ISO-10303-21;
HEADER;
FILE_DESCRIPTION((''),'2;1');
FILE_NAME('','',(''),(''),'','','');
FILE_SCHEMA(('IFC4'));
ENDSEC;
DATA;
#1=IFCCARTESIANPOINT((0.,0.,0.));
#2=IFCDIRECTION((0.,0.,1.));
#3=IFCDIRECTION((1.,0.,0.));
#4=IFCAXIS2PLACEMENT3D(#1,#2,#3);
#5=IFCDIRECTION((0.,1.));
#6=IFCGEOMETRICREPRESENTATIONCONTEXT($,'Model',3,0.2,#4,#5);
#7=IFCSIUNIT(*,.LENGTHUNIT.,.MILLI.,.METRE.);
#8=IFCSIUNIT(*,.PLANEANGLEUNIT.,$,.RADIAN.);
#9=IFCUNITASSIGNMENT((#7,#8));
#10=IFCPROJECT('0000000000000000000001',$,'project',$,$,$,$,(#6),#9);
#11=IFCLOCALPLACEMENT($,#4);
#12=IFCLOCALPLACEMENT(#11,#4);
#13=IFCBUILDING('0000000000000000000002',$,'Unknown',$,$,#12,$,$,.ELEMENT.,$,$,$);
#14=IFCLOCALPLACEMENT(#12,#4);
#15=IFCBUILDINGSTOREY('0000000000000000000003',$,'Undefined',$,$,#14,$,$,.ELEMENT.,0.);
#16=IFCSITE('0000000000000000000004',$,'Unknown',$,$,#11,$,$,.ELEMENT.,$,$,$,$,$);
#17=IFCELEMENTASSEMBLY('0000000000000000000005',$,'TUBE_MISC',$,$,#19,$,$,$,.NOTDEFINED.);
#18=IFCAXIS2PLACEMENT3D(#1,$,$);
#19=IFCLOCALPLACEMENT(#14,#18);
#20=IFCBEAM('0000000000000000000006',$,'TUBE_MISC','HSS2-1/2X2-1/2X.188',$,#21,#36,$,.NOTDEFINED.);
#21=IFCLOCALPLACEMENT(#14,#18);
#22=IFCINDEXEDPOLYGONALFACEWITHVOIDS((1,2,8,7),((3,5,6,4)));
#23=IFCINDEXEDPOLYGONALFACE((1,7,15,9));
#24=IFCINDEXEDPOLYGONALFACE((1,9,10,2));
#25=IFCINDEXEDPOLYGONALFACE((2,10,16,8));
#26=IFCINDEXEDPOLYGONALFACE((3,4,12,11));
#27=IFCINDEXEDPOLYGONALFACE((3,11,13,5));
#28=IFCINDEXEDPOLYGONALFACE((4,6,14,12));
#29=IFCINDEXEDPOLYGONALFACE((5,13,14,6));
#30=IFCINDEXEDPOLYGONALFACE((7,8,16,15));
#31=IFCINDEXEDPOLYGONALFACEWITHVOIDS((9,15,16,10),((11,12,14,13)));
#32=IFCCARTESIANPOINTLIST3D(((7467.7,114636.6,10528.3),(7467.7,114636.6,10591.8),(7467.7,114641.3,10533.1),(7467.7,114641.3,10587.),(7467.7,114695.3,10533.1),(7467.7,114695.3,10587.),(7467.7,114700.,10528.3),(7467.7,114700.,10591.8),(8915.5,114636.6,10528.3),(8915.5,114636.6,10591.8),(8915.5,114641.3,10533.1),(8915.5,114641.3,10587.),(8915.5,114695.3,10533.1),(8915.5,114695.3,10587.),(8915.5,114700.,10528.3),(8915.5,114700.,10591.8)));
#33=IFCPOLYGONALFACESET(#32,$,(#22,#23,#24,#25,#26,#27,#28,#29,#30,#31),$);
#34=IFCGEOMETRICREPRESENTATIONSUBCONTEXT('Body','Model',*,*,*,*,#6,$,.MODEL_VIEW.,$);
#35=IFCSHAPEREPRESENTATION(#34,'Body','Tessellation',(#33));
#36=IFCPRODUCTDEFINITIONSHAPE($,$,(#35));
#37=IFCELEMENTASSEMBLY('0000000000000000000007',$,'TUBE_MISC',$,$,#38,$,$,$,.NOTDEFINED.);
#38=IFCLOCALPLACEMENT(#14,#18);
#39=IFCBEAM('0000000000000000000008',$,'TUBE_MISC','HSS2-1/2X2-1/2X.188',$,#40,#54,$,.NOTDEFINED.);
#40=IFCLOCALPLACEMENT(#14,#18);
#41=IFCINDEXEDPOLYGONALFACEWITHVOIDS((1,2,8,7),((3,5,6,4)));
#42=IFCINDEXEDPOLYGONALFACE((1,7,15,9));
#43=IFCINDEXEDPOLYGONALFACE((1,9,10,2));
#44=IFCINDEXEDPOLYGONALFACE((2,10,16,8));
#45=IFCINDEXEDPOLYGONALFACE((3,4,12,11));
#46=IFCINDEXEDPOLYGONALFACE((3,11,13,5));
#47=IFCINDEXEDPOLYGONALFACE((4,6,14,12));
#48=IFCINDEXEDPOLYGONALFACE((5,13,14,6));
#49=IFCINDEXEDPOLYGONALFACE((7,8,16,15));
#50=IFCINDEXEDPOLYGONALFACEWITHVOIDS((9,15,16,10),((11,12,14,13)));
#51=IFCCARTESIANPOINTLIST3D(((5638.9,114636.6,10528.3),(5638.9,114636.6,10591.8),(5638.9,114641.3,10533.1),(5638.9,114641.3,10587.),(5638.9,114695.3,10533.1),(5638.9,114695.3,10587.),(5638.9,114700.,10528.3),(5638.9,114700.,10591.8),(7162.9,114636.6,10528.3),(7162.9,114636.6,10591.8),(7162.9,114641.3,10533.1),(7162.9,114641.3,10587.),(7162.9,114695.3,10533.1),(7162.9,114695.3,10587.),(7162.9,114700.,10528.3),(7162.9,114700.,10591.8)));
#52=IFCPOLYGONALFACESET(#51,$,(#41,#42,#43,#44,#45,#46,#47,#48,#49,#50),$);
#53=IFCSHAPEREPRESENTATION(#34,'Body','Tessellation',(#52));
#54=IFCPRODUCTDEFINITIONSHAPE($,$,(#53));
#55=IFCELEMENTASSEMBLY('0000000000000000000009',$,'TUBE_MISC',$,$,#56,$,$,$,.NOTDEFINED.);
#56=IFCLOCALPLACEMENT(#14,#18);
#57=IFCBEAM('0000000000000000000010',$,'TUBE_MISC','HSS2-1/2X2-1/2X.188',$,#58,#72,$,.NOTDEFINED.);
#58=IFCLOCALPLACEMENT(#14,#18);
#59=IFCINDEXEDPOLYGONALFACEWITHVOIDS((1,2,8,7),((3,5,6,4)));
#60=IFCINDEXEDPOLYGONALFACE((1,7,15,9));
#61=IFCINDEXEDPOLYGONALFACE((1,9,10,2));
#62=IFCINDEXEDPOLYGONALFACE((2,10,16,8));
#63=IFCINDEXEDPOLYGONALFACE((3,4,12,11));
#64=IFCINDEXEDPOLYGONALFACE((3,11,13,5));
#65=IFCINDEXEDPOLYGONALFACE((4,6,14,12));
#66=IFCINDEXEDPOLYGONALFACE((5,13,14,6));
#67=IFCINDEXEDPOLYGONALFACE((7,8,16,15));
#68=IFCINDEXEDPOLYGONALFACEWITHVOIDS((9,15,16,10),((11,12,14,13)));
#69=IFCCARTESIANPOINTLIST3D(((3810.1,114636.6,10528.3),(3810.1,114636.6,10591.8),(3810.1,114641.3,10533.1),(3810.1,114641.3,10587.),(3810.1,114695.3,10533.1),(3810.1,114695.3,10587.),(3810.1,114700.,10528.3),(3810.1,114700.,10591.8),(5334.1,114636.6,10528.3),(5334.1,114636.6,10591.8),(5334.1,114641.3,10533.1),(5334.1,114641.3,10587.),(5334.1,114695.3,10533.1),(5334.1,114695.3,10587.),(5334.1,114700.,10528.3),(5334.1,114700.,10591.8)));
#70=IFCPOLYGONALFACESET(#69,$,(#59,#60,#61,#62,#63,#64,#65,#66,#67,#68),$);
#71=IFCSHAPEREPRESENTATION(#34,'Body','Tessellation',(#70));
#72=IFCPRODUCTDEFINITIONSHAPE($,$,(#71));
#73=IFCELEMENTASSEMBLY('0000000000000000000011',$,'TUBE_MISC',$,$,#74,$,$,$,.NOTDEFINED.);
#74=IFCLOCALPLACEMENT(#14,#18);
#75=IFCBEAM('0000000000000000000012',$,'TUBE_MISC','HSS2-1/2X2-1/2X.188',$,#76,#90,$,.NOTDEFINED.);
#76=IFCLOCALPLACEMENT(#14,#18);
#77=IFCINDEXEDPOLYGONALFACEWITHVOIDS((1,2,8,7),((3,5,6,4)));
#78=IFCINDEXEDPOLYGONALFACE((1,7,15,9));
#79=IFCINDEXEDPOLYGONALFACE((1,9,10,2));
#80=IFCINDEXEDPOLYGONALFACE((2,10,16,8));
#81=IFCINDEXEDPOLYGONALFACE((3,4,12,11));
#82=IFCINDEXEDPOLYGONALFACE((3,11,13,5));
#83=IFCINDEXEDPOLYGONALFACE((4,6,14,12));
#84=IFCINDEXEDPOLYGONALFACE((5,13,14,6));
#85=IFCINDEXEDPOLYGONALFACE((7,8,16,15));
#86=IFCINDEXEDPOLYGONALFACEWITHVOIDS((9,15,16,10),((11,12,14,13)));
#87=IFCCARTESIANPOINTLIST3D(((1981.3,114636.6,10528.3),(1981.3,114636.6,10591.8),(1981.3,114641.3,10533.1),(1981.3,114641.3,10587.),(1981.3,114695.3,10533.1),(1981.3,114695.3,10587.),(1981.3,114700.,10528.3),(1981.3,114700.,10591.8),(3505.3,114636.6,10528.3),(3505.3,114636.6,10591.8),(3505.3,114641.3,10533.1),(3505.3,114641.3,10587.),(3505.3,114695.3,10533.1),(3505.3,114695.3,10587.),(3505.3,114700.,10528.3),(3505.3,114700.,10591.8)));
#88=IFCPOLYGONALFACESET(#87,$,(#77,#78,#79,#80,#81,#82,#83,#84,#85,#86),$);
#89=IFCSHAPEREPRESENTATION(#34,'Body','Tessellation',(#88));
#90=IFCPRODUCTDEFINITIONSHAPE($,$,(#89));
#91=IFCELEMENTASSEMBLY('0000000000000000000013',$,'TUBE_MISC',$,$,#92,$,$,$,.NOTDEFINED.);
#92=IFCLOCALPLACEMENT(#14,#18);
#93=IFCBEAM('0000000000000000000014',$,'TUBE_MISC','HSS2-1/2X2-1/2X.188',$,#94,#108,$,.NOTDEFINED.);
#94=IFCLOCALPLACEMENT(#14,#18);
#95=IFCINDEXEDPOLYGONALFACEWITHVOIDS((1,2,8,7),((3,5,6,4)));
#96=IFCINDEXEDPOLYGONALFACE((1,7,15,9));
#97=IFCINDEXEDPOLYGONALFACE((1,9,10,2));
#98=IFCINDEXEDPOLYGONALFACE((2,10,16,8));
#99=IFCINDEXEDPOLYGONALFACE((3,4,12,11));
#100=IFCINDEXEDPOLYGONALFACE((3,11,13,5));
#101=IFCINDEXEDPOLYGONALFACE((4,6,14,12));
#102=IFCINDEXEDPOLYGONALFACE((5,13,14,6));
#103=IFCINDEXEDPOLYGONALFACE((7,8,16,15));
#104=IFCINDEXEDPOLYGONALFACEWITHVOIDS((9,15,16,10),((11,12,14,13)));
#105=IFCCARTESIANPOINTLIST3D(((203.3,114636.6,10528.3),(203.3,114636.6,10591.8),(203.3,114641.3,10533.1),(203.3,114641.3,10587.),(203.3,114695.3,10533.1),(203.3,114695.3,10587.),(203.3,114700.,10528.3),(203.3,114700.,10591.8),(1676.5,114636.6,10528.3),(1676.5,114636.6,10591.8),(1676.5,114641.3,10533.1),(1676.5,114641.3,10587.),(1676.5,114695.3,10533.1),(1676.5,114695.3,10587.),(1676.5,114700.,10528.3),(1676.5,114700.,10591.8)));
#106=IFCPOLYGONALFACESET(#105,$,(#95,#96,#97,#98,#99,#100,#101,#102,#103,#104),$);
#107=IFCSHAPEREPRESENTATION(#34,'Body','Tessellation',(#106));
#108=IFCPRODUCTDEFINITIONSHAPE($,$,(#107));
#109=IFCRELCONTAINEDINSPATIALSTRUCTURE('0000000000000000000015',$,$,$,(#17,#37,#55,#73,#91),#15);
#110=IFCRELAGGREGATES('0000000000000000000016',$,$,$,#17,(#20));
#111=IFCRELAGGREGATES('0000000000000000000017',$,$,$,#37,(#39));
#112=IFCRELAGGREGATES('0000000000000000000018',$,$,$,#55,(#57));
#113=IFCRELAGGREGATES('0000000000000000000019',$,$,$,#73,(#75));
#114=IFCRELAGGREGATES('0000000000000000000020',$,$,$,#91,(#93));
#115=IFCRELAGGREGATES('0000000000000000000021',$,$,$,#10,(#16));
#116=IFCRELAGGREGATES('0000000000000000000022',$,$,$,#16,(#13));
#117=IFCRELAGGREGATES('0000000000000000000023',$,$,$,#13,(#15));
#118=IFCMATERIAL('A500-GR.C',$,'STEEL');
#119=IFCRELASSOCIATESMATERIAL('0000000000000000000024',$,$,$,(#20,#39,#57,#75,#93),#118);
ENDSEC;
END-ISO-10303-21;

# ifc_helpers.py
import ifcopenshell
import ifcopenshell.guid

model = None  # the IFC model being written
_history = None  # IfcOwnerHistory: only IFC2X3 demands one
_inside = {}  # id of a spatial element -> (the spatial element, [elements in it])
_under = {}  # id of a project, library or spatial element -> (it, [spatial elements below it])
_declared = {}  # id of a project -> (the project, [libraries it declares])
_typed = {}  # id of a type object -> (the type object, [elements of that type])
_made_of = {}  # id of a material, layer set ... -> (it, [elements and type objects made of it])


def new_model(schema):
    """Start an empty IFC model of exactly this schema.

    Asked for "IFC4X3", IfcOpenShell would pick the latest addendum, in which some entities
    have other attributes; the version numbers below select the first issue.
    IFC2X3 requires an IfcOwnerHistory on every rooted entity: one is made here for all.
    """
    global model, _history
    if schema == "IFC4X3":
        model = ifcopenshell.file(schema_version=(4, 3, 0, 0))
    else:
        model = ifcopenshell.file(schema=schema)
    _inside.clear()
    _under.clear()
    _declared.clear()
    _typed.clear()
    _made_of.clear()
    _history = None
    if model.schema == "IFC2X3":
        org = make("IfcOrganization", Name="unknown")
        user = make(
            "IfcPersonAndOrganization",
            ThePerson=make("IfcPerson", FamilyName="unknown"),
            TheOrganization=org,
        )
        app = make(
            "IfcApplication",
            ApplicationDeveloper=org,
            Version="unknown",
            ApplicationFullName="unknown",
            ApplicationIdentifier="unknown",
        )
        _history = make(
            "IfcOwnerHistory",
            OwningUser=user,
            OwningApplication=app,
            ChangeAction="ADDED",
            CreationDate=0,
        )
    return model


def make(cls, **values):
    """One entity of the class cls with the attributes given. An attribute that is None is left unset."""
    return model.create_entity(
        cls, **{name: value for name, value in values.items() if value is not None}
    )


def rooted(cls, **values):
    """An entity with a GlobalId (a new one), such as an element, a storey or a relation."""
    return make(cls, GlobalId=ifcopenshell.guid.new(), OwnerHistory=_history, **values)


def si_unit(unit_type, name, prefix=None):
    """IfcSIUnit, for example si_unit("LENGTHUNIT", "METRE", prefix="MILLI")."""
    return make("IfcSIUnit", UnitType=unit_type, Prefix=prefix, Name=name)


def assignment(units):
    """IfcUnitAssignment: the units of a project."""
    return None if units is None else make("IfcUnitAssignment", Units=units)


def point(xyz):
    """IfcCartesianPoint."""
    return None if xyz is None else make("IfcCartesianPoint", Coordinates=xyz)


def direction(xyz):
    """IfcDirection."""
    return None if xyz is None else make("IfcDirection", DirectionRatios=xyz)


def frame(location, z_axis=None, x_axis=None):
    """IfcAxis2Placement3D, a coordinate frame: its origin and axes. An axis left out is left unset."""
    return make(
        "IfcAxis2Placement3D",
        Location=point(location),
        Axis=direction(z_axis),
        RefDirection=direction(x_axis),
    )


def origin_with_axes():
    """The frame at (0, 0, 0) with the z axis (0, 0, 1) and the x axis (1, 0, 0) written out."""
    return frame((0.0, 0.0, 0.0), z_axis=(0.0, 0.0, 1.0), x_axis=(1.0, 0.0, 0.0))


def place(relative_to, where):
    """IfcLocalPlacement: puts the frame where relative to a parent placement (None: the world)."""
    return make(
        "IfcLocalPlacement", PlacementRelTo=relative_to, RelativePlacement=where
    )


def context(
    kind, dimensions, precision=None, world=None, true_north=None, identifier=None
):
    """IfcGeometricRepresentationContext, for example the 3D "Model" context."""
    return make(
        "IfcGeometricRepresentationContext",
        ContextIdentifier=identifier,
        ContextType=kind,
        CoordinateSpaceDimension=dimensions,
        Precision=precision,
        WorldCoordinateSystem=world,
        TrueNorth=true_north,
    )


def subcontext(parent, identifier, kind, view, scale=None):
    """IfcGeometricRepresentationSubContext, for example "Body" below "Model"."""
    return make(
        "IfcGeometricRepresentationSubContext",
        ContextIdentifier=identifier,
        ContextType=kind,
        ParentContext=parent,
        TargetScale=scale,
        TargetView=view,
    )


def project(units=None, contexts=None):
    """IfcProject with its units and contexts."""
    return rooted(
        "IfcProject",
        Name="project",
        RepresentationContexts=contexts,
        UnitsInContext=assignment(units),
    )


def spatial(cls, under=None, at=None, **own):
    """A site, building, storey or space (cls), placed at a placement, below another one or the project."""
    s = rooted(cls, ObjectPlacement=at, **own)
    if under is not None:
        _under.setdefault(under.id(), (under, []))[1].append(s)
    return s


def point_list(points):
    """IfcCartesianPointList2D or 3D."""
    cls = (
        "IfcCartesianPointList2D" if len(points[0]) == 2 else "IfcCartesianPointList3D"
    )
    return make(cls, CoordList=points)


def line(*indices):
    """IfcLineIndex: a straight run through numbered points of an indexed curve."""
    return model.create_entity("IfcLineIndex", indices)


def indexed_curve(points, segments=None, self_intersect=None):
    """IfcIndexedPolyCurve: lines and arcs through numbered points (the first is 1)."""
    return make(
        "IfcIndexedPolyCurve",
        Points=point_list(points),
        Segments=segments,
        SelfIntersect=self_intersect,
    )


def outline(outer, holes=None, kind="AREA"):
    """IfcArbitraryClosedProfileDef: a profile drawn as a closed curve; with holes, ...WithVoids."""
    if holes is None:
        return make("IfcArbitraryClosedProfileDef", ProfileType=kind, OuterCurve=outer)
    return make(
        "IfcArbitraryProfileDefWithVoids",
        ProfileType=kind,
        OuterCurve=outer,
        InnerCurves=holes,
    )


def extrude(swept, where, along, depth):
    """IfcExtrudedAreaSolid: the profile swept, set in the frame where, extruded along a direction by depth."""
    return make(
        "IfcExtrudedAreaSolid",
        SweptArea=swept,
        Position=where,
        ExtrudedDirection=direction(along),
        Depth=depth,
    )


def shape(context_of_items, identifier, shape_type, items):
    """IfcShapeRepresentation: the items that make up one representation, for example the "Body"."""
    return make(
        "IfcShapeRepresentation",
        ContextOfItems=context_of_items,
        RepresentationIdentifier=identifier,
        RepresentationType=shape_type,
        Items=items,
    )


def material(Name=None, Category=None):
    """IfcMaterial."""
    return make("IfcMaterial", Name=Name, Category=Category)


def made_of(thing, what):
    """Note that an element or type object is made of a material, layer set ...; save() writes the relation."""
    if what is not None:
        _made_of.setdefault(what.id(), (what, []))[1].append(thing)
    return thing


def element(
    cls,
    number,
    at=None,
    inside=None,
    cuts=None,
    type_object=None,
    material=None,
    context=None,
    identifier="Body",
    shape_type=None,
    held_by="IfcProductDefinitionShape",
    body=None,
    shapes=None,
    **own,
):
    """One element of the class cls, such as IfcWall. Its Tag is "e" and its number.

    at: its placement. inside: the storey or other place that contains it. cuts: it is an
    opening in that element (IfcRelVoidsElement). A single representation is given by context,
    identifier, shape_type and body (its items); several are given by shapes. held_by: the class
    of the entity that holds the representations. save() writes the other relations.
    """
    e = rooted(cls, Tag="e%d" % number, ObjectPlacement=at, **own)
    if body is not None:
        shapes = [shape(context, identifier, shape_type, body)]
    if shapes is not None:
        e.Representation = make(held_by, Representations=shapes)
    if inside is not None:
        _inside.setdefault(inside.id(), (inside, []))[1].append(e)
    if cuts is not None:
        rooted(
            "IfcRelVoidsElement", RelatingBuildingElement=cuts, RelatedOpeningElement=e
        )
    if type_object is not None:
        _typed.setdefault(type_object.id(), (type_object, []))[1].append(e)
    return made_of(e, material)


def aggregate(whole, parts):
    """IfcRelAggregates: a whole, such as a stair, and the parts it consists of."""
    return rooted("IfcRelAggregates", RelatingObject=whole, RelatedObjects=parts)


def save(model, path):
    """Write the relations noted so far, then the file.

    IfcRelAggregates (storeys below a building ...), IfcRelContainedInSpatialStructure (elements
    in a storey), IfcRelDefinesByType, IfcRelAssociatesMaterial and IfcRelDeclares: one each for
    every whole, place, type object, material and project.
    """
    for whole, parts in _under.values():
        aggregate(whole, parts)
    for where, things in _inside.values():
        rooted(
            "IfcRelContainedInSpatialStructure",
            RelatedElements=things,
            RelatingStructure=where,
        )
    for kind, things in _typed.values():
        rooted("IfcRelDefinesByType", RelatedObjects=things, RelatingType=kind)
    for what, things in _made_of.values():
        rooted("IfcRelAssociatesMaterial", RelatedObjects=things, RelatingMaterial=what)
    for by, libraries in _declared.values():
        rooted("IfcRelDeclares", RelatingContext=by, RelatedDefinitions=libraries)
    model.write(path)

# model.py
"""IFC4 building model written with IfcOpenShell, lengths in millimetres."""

from ifc_helpers import new_model, si_unit, direction, frame, origin_with_axes, place, context, subcontext, project, spatial, line, indexed_curve, outline, extrude, material, element, aggregate, save


model = new_model("IFC4")

# Units and contexts
model_context = context("Model", 3, precision=0.2, world=origin_with_axes(), true_north=direction((0.0, 1.0)))
body_context = subcontext(model_context, "Body", "Model", "MODEL_VIEW")
ifc_project = project(units=[si_unit("LENGTHUNIT", "METRE", prefix="MILLI"), si_unit("PLANEANGLEUNIT", "RADIAN")], contexts=[model_context])

# Site, building, storey
site_placement = place(None, origin_with_axes())
site = spatial("IfcSite", under=ifc_project, at=site_placement, Name="Unknown", CompositionType="ELEMENT")
building_placement = place(site_placement, origin_with_axes())
building = spatial("IfcBuilding", under=site, at=building_placement, Name="Unknown", CompositionType="ELEMENT")
storey_placement = place(building_placement, origin_with_axes())
storey = spatial("IfcBuildingStorey", under=building, at=storey_placement, Name="Undefined", CompositionType="ELEMENT", Elevation=0.0)

# Element assemblies, beams
assembly_1_placement = place(storey_placement, frame((7467.7, 114668.3, 10560.0), z_axis=(0.0, -1.0, 0.0), x_axis=(1.0, 0.0, 0.0)))
assembly_1 = element("IfcElementAssembly", 1, at=assembly_1_placement, inside=storey, Name="TUBE_MISC", PredefinedType="NOTDEFINED")
ifc_material_1 = material(Name="A500-GR.C", Category="STEEL")
beam_1_placement = place(assembly_1_placement, origin_with_axes())
beam_1 = element("IfcBeam", 2, at=beam_1_placement, material=ifc_material_1, Name="TUBE_MISC", Description="HSS2-1/2X2-1/2X.188", PredefinedType="NOTDEFINED", context=body_context, shape_type="SolidModel", body=[
    extrude(outline(indexed_curve([(-31.8, -31.8), (31.8, -31.8), (31.8, 31.8), (-31.8, 31.8)], segments=[line(1, 2, 3, 4, 1)]), holes=[indexed_curve([(-27.0, -27.0), (-27.0, 27.0), (27.0, 27.0), (27.0, -27.0)], segments=[line(1, 2, 3, 4, 1)])]), frame((0.0, 0.0, 0.0), z_axis=(-1.0, 0.0, 0.0), x_axis=(0.0, 0.0, 1.0)), (0.0, 0.0, -1.0), 1447.8),
])
aggregate(assembly_1, [beam_1])
assembly_2_placement = place(storey_placement, frame((5638.9, 114668.3, 10560.0), z_axis=(0.0, -1.0, 0.0), x_axis=(1.0, 0.0, 0.0)))
assembly_2 = element("IfcElementAssembly", 3, at=assembly_2_placement, inside=storey, Name="TUBE_MISC", PredefinedType="NOTDEFINED")
beam_2_placement = place(assembly_2_placement, origin_with_axes())
beam_2 = element("IfcBeam", 4, at=beam_2_placement, material=ifc_material_1, Name="TUBE_MISC", Description="HSS2-1/2X2-1/2X.188", PredefinedType="NOTDEFINED", context=body_context, shape_type="SolidModel", body=[
    extrude(outline(indexed_curve([(-31.8, -31.8), (31.8, -31.8), (31.8, 31.8), (-31.8, 31.8)], segments=[line(1, 2, 3, 4, 1)]), holes=[indexed_curve([(-27.0, -27.0), (-27.0, 27.0), (27.0, 27.0), (27.0, -27.0)], segments=[line(1, 2, 3, 4, 1)])]), frame((0.0, 0.0, 0.0), z_axis=(-1.0, 0.0, 0.0), x_axis=(0.0, 0.0, 1.0)), (0.0, 0.0, -1.0), 1524.0),
])
aggregate(assembly_2, [beam_2])
assembly_3_placement = place(storey_placement, frame((3810.1, 114668.3, 10560.0), z_axis=(0.0, -1.0, 0.0), x_axis=(1.0, 0.0, 0.0)))
assembly_3 = element("IfcElementAssembly", 5, at=assembly_3_placement, inside=storey, Name="TUBE_MISC", PredefinedType="NOTDEFINED")
beam_3_placement = place(assembly_3_placement, origin_with_axes())
beam_3 = element("IfcBeam", 6, at=beam_3_placement, material=ifc_material_1, Name="TUBE_MISC", Description="HSS2-1/2X2-1/2X.188", PredefinedType="NOTDEFINED", context=body_context, shape_type="SolidModel", body=[
    extrude(outline(indexed_curve([(-31.8, -31.8), (31.8, -31.8), (31.8, 31.8), (-31.8, 31.8)], segments=[line(1, 2, 3, 4, 1)]), holes=[indexed_curve([(-27.0, -27.0), (-27.0, 27.0), (27.0, 27.0), (27.0, -27.0)], segments=[line(1, 2, 3, 4, 1)])]), frame((0.0, 0.0, 0.0), z_axis=(-1.0, 0.0, 0.0), x_axis=(0.0, 0.0, 1.0)), (0.0, 0.0, -1.0), 1524.0),
])
aggregate(assembly_3, [beam_3])
assembly_4_placement = place(storey_placement, frame((1981.3, 114668.3, 10560.0), z_axis=(0.0, -1.0, 0.0), x_axis=(1.0, 0.0, 0.0)))
assembly_4 = element("IfcElementAssembly", 7, at=assembly_4_placement, inside=storey, Name="TUBE_MISC", PredefinedType="NOTDEFINED")
beam_4_placement = place(assembly_4_placement, origin_with_axes())
beam_4 = element("IfcBeam", 8, at=beam_4_placement, material=ifc_material_1, Name="TUBE_MISC", Description="HSS2-1/2X2-1/2X.188", PredefinedType="NOTDEFINED", context=body_context, shape_type="SolidModel", body=[
    extrude(outline(indexed_curve([(-31.8, -31.8), (31.8, -31.8), (31.8, 31.8), (-31.8, 31.8)], segments=[line(1, 2, 3, 4, 1)]), holes=[indexed_curve([(-27.0, -27.0), (-27.0, 27.0), (27.0, 27.0), (27.0, -27.0)], segments=[line(1, 2, 3, 4, 1)])]), frame((0.0, 0.0, 0.0), z_axis=(-1.0, 0.0, 0.0), x_axis=(0.0, 0.0, 1.0)), (0.0, 0.0, -1.0), 1524.0),
])
aggregate(assembly_4, [beam_4])
assembly_5_placement = place(storey_placement, frame((203.3, 114668.3, 10560.0), z_axis=(0.0, -1.0, 0.0), x_axis=(1.0, 0.0, 0.0)))
assembly_5 = element("IfcElementAssembly", 9, at=assembly_5_placement, inside=storey, Name="TUBE_MISC", PredefinedType="NOTDEFINED")
beam_5_placement = place(assembly_5_placement, origin_with_axes())
beam_5 = element("IfcBeam", 10, at=beam_5_placement, material=ifc_material_1, Name="TUBE_MISC", Description="HSS2-1/2X2-1/2X.188", PredefinedType="NOTDEFINED", context=body_context, shape_type="SolidModel", body=[
    extrude(outline(indexed_curve([(-31.8, -31.8), (31.8, -31.8), (31.8, 31.8), (-31.8, 31.8)], segments=[line(1, 2, 3, 4, 1)]), holes=[indexed_curve([(-27.0, -27.0), (-27.0, 27.0), (27.0, 27.0), (27.0, -27.0)], segments=[line(1, 2, 3, 4, 1)])]), frame((0.0, 0.0, 0.0), z_axis=(-1.0, 0.0, 0.0), x_axis=(0.0, 0.0, 1.0)), (0.0, 0.0, -1.0), 1473.2),
])
aggregate(assembly_5, [beam_5])

save(model, "model.ifc")
